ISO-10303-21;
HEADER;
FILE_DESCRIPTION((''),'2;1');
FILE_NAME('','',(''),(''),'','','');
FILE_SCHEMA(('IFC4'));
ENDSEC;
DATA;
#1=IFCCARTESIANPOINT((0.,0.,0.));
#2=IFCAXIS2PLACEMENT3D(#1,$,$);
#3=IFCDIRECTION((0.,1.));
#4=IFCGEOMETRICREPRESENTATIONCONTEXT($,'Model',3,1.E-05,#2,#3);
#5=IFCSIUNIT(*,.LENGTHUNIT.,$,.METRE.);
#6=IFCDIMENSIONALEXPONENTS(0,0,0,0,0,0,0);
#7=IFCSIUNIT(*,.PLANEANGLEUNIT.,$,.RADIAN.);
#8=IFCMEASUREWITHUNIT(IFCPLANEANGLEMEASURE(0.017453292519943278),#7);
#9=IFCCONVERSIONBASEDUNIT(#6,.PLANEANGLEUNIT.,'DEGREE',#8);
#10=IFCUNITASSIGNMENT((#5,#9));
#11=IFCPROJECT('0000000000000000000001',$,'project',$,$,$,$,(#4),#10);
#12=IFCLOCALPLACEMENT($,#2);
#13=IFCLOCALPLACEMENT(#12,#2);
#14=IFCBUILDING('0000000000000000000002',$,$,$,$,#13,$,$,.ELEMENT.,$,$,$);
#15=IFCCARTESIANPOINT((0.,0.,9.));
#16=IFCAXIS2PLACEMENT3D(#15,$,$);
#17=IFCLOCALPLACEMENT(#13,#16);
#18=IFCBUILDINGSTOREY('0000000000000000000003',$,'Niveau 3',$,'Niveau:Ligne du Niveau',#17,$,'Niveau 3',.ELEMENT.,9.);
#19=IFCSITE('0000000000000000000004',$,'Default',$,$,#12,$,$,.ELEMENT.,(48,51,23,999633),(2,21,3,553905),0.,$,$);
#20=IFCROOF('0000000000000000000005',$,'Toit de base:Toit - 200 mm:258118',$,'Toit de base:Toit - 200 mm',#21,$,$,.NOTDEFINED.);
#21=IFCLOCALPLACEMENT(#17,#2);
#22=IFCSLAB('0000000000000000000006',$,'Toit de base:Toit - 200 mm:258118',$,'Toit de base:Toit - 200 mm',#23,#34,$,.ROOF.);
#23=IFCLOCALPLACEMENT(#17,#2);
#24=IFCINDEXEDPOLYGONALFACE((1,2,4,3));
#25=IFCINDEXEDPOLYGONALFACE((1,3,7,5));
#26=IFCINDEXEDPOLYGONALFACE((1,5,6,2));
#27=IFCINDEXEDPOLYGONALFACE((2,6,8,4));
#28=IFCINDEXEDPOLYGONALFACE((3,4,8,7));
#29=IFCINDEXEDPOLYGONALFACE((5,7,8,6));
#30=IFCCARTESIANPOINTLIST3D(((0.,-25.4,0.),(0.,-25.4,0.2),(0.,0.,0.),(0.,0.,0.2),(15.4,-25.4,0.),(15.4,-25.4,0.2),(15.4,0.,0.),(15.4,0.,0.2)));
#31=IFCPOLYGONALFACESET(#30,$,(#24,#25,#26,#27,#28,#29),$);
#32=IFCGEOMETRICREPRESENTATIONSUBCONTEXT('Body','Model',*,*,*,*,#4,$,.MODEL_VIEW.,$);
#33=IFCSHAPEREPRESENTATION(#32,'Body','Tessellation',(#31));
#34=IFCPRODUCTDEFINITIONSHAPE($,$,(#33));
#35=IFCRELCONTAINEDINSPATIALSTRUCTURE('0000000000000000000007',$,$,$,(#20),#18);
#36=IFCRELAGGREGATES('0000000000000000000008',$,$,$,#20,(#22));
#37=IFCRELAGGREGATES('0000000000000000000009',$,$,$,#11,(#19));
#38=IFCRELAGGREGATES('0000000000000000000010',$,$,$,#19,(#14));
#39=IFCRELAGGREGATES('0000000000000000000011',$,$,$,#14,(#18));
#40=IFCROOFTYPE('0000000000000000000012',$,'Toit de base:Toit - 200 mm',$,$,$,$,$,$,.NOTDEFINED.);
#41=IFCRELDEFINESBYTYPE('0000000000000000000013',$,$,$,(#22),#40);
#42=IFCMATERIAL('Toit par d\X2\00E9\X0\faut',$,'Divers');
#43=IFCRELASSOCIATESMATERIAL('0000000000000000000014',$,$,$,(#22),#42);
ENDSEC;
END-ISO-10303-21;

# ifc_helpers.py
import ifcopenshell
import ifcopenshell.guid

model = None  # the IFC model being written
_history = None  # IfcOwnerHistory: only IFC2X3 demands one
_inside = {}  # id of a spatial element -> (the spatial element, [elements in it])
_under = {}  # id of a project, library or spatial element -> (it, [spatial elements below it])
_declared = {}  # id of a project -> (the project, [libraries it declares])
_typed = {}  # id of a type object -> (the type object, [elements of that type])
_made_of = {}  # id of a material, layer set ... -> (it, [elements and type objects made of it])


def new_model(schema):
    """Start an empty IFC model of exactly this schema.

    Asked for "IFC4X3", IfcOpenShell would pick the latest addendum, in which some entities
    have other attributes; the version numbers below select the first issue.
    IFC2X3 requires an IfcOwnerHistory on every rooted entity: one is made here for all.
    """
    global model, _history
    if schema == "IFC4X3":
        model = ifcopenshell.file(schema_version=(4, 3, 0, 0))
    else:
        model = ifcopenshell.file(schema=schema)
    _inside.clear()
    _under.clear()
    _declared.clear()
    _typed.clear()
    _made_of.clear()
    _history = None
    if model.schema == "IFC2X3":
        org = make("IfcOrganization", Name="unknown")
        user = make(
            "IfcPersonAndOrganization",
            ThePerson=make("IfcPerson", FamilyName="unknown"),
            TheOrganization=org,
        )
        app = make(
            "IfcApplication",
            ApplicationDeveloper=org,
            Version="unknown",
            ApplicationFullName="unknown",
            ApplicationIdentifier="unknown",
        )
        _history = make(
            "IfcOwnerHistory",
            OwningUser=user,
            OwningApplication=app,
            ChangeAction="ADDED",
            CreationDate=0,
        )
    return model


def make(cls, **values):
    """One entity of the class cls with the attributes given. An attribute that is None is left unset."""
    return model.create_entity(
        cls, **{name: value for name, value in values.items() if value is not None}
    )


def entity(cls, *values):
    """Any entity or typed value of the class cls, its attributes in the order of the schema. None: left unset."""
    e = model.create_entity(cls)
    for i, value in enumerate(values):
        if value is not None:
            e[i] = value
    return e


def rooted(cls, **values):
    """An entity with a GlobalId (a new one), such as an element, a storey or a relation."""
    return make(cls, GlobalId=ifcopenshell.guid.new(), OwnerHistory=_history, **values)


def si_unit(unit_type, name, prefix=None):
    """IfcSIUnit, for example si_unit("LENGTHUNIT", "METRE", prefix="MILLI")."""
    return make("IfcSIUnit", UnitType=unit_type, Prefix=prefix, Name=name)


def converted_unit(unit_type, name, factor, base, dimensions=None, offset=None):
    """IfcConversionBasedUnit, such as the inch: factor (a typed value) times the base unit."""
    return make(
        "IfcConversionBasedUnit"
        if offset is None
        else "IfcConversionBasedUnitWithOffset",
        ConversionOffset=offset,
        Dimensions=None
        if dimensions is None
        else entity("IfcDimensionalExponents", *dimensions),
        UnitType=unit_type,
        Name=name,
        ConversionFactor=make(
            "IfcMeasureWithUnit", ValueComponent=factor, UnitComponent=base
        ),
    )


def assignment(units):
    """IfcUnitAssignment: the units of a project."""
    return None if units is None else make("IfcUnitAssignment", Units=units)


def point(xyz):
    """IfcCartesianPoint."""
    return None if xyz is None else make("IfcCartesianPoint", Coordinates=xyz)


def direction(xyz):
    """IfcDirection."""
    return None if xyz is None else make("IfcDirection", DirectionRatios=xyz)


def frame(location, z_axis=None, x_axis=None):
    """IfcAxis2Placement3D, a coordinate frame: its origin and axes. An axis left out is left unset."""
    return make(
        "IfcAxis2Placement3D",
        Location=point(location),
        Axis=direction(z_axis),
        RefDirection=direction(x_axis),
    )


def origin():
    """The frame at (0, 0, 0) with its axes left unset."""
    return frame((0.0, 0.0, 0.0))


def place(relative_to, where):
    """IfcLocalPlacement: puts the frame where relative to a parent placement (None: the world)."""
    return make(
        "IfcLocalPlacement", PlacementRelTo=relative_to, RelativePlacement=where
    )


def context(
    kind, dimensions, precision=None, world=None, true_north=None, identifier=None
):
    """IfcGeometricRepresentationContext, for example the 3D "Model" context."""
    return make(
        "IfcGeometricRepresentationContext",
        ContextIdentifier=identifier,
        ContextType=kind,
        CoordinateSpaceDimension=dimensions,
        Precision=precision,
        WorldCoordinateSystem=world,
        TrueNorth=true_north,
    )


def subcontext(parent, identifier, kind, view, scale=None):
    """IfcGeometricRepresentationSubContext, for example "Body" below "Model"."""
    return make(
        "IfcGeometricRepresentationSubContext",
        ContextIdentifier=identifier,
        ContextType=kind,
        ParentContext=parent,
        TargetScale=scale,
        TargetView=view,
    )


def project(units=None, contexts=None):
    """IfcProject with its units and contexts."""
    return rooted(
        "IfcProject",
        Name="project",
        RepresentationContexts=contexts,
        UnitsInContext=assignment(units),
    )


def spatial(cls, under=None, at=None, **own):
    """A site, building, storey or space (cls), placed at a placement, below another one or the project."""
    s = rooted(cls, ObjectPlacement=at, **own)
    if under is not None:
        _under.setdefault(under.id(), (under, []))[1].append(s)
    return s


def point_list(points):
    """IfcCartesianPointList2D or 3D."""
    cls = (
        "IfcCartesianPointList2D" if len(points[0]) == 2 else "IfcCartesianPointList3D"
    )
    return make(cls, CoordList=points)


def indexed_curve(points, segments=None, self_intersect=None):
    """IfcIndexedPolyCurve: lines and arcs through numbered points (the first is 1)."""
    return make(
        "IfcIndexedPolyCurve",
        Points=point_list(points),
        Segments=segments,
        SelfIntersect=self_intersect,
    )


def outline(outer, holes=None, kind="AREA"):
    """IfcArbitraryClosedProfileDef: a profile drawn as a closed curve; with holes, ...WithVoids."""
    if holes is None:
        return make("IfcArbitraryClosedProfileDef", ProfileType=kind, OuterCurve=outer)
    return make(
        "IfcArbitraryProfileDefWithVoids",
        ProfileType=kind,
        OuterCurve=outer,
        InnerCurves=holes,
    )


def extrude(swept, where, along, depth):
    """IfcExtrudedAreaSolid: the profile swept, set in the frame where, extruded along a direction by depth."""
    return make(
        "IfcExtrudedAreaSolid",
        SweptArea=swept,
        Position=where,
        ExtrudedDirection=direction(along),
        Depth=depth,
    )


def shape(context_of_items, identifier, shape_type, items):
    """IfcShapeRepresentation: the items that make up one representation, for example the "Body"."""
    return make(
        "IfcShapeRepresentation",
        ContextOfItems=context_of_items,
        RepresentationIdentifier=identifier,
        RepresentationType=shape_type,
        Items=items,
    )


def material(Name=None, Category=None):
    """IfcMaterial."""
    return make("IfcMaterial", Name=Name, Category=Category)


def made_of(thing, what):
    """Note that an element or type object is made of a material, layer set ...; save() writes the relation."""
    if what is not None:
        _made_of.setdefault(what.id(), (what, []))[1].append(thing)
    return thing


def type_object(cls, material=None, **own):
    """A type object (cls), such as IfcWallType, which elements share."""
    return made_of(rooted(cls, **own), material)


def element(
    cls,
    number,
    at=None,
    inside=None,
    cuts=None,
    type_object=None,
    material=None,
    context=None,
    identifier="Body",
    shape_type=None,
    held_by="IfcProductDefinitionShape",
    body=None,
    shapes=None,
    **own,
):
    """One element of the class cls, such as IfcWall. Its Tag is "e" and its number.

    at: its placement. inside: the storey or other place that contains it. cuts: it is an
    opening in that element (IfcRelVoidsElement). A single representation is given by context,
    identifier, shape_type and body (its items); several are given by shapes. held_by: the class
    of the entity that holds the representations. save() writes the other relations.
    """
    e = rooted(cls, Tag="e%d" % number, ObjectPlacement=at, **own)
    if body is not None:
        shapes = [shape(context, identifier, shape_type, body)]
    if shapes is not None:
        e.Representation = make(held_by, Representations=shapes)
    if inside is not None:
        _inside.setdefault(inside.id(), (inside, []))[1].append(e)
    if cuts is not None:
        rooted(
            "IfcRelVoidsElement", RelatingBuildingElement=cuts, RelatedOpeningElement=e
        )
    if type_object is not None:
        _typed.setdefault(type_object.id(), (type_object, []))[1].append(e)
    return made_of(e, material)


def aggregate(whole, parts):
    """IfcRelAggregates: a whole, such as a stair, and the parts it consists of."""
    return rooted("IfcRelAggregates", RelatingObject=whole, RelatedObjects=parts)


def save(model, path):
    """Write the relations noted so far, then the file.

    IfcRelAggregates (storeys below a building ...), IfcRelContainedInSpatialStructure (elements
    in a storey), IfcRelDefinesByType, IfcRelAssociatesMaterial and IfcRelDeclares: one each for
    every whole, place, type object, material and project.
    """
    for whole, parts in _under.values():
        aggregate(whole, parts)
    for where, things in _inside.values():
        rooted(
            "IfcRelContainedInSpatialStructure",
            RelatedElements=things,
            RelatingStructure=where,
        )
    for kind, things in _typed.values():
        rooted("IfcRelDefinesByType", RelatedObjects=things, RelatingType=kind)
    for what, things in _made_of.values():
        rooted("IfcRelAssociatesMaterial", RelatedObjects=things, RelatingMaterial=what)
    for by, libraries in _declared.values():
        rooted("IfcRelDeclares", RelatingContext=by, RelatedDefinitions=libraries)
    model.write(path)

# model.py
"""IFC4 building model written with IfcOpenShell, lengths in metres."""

from ifc_helpers import new_model, entity, si_unit, converted_unit, direction, frame, origin, place, context, subcontext, project, spatial, indexed_curve, outline, extrude, material, type_object, element, aggregate, save


model = new_model("IFC4")

# Units and contexts
model_context = context("Model", 3, precision=1e-05, world=origin(), true_north=direction((0.0, 1.0)))
body_context = subcontext(model_context, "Body", "Model", "MODEL_VIEW")
ifc_project = project(units=[si_unit("LENGTHUNIT", "METRE"), converted_unit("PLANEANGLEUNIT", "DEGREE", entity("IfcPlaneAngleMeasure", 0.017453292519943278), si_unit("PLANEANGLEUNIT", "RADIAN"), dimensions=[0, 0, 0, 0, 0, 0, 0])], contexts=[model_context])

# Site, building, storey
site_placement = place(None, origin())
site = spatial("IfcSite", under=ifc_project, at=site_placement, Name="Default", CompositionType="ELEMENT", RefLatitude=(48, 51, 23, 999633), RefLongitude=(2, 21, 3, 553905), RefElevation=0.0)
building_placement = place(site_placement, origin())
building = spatial("IfcBuilding", under=site, at=building_placement, CompositionType="ELEMENT")
storey_placement = place(building_placement, frame((0.0, 0.0, 9.0)))
storey = spatial("IfcBuildingStorey", under=building, at=storey_placement, Name="Niveau 3", ObjectType="Niveau:Ligne du Niveau", LongName="Niveau 3", CompositionType="ELEMENT", Elevation=9.0)

# Roof, slab
roof_placement = place(storey_placement, frame((0.0, -25.4, 0.0)))
roof = element("IfcRoof", 1, at=roof_placement, inside=storey, Name="Toit de base:Toit - 200 mm:258118", ObjectType="Toit de base:Toit - 200 mm", PredefinedType="NOTDEFINED")
ifc_material = material(Name="Toit par défaut", Category="Divers")
roof_type = type_object("IfcRoofType", Name="Toit de base:Toit - 200 mm", PredefinedType="NOTDEFINED")
slab_placement = place(roof_placement, origin())
slab = element("IfcSlab", 2, at=slab_placement, type_object=roof_type, material=ifc_material, Name="Toit de base:Toit - 200 mm:258118", ObjectType="Toit de base:Toit - 200 mm", PredefinedType="ROOF", context=body_context, shape_type="SweptSolid", body=[
    extrude(outline(indexed_curve([(-7.7, 12.7), (-7.7, -12.7), (7.7, -12.7), (7.7, 12.7), (-7.7, 12.7)], self_intersect=False)), frame((7.7, 12.7, 0.0)), (0.0, 0.0, 1.0), 0.2),
])
aggregate(roof, [slab])

save(model, "model.ifc")
